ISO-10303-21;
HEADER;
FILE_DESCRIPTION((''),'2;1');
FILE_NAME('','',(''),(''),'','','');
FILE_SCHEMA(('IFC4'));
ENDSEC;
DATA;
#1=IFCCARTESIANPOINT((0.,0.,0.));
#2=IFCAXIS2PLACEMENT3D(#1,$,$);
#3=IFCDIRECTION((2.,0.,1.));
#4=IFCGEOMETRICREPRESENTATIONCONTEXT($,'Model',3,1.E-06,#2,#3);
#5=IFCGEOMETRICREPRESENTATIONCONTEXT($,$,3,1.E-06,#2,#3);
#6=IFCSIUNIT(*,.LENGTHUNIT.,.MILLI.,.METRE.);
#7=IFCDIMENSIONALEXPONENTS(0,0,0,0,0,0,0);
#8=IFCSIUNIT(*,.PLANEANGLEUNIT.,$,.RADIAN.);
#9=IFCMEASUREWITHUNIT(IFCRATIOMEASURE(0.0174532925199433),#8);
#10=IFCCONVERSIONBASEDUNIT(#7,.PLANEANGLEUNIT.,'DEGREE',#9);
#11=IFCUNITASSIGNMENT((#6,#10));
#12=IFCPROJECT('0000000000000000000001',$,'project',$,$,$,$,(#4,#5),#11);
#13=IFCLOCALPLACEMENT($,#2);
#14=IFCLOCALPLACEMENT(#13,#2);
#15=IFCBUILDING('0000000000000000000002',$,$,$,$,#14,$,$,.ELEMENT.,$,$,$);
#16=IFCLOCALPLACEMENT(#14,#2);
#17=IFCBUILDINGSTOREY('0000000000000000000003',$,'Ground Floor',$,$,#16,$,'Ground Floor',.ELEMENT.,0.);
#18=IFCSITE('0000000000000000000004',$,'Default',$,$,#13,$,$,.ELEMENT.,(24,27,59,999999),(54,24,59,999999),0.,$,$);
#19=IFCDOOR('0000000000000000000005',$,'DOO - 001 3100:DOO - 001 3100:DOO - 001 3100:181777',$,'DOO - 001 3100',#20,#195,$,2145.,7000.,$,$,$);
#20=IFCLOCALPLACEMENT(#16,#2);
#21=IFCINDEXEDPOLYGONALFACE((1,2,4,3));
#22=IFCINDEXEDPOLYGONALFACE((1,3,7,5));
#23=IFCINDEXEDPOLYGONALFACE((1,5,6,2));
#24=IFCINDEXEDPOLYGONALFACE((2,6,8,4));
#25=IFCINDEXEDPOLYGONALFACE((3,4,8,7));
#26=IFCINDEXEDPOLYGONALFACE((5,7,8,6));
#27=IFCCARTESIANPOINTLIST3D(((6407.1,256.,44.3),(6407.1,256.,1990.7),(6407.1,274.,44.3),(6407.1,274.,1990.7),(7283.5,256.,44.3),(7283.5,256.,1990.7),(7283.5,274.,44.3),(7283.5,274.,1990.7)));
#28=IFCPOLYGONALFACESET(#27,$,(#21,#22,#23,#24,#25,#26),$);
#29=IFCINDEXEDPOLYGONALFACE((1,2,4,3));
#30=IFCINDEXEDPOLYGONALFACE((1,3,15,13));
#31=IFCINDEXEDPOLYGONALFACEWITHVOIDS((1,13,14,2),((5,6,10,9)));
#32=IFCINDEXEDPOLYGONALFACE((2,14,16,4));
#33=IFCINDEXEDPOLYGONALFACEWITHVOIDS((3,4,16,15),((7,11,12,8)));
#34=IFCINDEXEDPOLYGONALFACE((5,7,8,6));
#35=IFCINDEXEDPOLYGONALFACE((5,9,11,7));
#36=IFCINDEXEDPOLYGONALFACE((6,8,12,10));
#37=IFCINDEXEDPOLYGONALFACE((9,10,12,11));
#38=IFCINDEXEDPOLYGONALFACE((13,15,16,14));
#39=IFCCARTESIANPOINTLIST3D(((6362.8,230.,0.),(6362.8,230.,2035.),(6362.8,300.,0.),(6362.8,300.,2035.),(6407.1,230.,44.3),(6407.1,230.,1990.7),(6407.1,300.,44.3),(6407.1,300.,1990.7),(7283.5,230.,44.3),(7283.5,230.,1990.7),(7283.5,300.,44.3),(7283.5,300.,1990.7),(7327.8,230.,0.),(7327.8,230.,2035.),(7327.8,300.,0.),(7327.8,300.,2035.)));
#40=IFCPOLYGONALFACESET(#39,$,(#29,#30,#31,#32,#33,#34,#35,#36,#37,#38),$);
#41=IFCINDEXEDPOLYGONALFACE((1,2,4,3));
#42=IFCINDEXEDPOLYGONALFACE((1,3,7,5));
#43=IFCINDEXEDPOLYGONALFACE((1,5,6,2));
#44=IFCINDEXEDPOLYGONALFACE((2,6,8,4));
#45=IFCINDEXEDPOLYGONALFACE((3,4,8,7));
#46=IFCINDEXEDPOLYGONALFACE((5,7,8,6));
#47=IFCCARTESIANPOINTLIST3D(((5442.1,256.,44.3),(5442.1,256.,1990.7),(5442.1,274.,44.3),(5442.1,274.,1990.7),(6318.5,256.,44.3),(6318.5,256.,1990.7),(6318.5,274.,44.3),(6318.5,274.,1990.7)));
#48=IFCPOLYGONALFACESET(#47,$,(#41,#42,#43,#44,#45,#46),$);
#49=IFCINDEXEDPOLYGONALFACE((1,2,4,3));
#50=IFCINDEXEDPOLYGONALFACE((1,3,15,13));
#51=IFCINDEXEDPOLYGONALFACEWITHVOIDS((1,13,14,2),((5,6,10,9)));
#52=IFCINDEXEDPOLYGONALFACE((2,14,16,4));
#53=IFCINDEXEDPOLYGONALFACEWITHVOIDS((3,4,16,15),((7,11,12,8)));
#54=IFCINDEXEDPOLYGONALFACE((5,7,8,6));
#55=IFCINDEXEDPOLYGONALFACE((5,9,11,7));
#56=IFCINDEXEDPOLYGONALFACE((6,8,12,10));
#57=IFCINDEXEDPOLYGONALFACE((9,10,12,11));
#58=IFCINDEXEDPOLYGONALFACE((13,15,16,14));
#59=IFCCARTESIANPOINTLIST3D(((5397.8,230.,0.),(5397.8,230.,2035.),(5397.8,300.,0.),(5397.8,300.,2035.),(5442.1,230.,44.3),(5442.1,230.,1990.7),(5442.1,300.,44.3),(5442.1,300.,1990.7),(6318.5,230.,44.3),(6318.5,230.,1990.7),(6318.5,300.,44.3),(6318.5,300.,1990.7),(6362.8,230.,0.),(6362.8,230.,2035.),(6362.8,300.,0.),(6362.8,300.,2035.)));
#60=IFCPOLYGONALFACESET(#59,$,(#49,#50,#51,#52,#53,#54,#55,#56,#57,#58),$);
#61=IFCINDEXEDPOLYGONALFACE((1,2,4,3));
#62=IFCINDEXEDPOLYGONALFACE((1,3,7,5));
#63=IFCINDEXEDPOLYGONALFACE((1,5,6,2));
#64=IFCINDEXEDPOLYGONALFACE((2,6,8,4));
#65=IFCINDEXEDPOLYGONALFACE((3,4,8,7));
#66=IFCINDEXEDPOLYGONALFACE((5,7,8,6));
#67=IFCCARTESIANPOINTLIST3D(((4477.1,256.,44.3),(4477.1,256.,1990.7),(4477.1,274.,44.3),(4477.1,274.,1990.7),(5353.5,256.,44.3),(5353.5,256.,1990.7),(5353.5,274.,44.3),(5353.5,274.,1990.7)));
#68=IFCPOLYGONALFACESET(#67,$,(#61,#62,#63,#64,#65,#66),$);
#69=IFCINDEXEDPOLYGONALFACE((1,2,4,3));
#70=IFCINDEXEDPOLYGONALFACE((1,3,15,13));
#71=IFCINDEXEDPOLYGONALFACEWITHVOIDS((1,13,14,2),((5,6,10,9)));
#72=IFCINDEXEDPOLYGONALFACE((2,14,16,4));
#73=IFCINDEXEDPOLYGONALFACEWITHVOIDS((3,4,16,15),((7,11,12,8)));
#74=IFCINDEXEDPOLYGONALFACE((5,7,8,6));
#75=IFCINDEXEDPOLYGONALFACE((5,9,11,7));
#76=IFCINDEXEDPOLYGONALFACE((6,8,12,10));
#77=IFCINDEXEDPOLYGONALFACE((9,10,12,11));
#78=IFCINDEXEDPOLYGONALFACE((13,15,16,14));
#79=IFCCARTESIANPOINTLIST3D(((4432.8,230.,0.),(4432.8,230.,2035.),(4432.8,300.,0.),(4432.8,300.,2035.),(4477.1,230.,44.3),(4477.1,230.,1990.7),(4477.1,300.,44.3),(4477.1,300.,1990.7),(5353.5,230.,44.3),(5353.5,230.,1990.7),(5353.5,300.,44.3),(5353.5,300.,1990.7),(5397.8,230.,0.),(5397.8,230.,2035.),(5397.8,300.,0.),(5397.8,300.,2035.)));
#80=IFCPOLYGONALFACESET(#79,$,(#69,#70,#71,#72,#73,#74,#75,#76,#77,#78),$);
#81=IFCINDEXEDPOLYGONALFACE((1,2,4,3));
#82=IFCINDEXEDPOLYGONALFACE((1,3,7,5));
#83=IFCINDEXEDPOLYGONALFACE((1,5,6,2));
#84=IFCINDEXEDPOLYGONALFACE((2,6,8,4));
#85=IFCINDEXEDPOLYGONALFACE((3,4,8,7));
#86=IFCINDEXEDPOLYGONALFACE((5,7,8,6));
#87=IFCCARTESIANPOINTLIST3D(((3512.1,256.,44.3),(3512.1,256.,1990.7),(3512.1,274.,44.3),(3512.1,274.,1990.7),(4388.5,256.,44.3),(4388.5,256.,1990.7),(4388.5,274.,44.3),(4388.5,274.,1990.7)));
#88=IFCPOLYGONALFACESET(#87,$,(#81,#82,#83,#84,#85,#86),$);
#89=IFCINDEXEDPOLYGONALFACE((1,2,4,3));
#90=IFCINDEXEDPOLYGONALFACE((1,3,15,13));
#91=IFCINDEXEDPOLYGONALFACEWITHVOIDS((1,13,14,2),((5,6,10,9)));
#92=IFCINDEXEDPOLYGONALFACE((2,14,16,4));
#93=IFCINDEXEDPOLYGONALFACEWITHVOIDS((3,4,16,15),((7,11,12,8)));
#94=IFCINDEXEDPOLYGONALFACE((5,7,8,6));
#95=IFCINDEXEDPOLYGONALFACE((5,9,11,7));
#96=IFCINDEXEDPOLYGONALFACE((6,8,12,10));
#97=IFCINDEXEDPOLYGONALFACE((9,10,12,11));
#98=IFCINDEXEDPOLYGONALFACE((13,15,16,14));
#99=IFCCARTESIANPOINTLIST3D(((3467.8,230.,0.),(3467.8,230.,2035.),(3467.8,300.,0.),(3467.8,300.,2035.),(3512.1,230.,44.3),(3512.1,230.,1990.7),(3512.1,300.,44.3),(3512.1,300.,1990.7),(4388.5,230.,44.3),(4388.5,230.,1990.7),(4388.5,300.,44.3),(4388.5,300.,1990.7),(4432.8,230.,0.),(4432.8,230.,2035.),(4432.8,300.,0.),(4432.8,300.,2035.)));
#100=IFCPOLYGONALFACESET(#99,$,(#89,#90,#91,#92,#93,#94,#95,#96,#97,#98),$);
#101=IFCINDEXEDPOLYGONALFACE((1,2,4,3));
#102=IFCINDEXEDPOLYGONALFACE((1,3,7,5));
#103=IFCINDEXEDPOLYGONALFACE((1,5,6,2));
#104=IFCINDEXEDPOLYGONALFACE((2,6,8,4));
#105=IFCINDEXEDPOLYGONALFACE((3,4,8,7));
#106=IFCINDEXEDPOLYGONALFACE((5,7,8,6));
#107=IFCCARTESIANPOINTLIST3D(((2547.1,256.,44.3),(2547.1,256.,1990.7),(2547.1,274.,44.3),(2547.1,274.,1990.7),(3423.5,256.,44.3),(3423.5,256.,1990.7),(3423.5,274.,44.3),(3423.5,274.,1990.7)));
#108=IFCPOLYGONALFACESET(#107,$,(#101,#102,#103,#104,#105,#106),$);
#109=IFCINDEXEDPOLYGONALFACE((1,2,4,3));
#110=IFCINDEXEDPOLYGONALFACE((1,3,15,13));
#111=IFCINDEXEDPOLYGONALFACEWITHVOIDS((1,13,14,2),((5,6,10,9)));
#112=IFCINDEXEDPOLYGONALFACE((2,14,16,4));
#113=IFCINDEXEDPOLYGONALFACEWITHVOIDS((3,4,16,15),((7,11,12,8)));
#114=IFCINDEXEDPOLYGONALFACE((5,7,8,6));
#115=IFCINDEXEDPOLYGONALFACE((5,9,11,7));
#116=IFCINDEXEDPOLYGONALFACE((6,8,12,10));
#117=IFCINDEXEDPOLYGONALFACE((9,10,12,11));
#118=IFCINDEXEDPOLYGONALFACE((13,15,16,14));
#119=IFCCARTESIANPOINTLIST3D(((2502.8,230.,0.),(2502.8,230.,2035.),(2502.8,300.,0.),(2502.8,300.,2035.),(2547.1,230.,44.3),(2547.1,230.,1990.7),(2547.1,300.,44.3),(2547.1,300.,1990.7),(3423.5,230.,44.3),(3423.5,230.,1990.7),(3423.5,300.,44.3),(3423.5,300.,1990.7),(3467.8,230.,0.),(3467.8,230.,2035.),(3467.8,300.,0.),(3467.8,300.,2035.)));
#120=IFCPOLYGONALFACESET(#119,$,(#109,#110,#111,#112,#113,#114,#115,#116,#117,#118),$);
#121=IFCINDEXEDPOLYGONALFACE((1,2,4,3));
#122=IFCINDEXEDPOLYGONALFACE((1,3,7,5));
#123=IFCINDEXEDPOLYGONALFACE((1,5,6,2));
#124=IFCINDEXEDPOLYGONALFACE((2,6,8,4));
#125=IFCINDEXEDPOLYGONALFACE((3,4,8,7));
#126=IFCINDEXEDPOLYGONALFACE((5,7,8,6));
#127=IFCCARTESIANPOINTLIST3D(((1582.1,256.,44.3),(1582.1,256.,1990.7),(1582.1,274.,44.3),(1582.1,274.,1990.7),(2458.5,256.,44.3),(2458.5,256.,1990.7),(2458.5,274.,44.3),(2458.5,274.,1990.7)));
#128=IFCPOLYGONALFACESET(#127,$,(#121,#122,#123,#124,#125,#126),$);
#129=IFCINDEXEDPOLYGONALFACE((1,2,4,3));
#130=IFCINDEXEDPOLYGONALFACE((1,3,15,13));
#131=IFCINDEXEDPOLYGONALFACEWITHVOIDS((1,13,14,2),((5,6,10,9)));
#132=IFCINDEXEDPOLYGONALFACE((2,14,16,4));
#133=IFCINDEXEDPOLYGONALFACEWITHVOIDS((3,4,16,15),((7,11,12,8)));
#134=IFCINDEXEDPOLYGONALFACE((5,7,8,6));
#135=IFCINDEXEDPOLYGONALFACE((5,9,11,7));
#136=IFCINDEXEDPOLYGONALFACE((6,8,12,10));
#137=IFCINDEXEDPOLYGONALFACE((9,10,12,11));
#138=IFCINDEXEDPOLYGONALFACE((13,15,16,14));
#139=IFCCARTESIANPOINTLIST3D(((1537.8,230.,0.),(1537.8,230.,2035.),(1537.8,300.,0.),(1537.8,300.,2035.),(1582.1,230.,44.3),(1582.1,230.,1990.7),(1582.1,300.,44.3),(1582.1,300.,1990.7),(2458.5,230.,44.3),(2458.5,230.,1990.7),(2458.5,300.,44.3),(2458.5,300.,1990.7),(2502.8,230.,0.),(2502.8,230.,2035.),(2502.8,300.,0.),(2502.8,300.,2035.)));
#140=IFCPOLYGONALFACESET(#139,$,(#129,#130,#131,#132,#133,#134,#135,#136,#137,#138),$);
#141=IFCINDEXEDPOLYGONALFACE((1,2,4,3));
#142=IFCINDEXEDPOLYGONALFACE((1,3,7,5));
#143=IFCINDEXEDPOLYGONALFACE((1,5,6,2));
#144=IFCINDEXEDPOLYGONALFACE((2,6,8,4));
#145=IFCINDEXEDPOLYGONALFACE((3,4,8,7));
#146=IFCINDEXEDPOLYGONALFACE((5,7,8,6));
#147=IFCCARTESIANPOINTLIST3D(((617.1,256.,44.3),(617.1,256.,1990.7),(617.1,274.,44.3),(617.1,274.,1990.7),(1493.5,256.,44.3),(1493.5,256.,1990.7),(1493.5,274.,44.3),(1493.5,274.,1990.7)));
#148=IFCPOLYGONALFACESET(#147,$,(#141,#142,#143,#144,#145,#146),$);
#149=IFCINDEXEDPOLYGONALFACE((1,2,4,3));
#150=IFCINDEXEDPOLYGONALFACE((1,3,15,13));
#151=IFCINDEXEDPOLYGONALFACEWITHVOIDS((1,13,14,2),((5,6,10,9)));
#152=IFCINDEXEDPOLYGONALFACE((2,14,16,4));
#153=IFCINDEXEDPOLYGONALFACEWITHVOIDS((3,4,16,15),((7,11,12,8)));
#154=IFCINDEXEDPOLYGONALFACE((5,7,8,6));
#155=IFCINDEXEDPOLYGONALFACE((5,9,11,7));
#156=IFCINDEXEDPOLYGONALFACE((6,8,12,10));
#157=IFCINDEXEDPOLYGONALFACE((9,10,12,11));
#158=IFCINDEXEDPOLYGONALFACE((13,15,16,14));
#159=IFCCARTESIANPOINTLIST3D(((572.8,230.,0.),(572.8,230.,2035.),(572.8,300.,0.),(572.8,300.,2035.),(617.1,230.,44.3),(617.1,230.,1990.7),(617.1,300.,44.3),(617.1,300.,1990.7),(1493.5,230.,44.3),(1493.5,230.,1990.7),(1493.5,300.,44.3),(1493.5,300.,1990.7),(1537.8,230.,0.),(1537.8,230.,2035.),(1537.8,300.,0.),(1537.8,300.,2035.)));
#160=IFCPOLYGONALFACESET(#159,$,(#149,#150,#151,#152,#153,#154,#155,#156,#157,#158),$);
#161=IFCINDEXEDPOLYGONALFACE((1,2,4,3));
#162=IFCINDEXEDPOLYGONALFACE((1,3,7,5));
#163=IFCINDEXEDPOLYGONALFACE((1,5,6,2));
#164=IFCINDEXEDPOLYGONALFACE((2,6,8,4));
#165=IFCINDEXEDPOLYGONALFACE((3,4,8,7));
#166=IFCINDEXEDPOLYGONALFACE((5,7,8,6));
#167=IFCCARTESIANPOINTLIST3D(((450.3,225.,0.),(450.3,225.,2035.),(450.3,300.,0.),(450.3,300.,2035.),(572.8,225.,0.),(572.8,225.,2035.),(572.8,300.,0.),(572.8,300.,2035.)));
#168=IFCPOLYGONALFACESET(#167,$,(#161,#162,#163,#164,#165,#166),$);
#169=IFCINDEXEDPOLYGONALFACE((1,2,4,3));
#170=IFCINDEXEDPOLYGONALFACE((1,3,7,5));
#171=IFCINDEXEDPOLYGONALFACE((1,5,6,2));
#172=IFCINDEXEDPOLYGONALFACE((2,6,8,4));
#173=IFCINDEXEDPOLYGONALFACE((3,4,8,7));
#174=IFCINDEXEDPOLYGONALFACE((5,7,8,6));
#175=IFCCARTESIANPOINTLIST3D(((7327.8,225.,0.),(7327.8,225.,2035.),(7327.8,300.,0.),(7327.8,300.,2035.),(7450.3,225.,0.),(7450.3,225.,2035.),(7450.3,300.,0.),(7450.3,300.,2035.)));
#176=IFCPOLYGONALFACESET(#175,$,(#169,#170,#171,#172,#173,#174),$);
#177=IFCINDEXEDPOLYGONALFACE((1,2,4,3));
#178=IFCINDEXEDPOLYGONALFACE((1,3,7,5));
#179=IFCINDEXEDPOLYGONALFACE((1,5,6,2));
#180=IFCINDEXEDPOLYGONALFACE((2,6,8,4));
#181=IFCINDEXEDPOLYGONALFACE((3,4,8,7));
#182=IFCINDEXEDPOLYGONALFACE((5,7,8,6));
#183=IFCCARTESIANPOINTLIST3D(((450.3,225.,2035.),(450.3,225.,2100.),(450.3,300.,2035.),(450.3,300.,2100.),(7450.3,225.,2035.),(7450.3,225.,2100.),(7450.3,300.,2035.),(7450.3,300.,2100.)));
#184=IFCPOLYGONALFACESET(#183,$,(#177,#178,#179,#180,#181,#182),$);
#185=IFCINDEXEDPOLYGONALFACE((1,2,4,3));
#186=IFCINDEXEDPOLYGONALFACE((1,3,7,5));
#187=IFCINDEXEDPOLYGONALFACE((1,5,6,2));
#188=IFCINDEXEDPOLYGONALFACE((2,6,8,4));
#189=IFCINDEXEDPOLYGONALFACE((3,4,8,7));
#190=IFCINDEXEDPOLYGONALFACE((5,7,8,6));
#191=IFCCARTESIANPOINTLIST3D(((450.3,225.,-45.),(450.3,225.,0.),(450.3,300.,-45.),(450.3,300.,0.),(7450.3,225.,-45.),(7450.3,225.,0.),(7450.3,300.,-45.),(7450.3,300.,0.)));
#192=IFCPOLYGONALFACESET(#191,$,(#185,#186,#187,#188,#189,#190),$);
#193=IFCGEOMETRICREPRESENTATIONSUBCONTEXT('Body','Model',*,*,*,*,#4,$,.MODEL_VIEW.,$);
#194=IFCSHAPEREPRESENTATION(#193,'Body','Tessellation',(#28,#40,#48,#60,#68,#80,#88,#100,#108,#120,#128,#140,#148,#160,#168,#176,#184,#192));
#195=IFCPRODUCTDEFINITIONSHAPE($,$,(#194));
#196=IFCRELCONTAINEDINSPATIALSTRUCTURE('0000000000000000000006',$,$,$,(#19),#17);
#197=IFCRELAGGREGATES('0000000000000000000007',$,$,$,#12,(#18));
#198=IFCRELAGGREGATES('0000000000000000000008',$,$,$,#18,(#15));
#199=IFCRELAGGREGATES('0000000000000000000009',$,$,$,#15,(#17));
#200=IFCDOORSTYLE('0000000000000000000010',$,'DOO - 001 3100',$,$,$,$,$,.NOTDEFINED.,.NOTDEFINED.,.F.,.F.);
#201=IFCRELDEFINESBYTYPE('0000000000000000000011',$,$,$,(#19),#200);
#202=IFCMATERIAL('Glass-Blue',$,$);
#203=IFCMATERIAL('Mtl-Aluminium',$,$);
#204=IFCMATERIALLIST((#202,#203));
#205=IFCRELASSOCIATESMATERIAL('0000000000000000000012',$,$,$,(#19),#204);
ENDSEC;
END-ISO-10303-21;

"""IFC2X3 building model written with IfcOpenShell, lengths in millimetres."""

from ifc_helpers import new_model, entity, si_unit, converted_unit, direction, frame, frame_2d, origin, origin_2d_with_axis, place, context, subcontext, project, spatial, polyline, rectangle, outline, extrude, source, transform, mapped, material, material_list, type_object, type_shapes, element, save


model = new_model("IFC2X3")

# Units and contexts
model_context = context("Model", 3, precision=1e-06, world=origin(), true_north=direction((2.0, 0.0, 1.0)))
context_of_model = context(None, 3, precision=1e-06, world=origin(), true_north=direction((2.0, 0.0, 1.0)))
body_context = subcontext(model_context, "Body", "Model", "MODEL_VIEW")
ifc_project = project(units=[si_unit("LENGTHUNIT", "METRE", prefix="MILLI"), converted_unit("PLANEANGLEUNIT", "DEGREE", entity("IfcRatioMeasure", 0.0174532925199433), si_unit("PLANEANGLEUNIT", "RADIAN"), dimensions=[0, 0, 0, 0, 0, 0, 0])], contexts=[model_context, context_of_model])

# Site, building, storey
site_placement = place(None, origin())
site = spatial("IfcSite", under=ifc_project, at=site_placement, Name="Default", CompositionType="ELEMENT", RefLatitude=(24, 27, 59, 999999), RefLongitude=(54, 24, 59, 999999), RefElevation=0.0)
building_placement = place(site_placement, origin())
building = spatial("IfcBuilding", under=site, at=building_placement, CompositionType="ELEMENT")
storey_placement = place(building_placement, origin())
storey = spatial("IfcBuildingStorey", under=building, at=storey_placement, Name="Ground Floor", LongName="Ground Floor", CompositionType="ELEMENT", Elevation=0.0)

# Door
ifc_material_1 = material(Name="Glass-Blue")
ifc_material_2 = material(Name="Mtl-Aluminium")
ifc_material_list = material_list([ifc_material_1, ifc_material_2])
door_style = type_object("IfcDoorStyle", Name="DOO - 001 3100", ConstructionType="NOTDEFINED", OperationType="NOTDEFINED", ParameterTakesPrecedence=False, Sizeable=False)
shared_shape = source(origin(), body_context, "Body", "SweptSolid", [
    extrude(rectangle(XDim=876.4, YDim=18.0, at=frame_2d((0.0, 0.0), x_axis=(1.0, 0.0))), frame((6845.3, 265.0, 44.3), z_axis=(0.0, 0.0, 1.0), x_axis=(-1.0, 0.0, 0.0)), (0.0, 0.0, 1.0), 1946.4),
    extrude(outline(polyline([(-482.5, -1017.5), (482.5, -1017.5), (482.5, 1017.5), (-482.5, 1017.5), (-482.5, -1017.5)]), holes=[polyline([(438.2, 973.2), (438.2, -973.2), (-438.2, -973.2), (-438.2, 973.2), (438.2, 973.2)])]), frame((6845.3, 230.0, 1017.5), z_axis=(0.0, 1.0, 0.0), x_axis=(-1.0, 0.0, 0.0)), (0.0, 0.0, 1.0), 70.0),
    extrude(rectangle(XDim=876.4, YDim=18.0, at=frame_2d((0.0, 0.0), x_axis=(1.0, 0.0))), frame((5880.3, 265.0, 44.3), z_axis=(0.0, 0.0, 1.0), x_axis=(-1.0, 0.0, 0.0)), (0.0, 0.0, 1.0), 1946.4),
    extrude(outline(polyline([(-482.5, -1017.5), (482.5, -1017.5), (482.5, 1017.5), (-482.5, 1017.5), (-482.5, -1017.5)]), holes=[polyline([(438.2, 973.2), (438.2, -973.2), (-438.2, -973.2), (-438.2, 973.2), (438.2, 973.2)])]), frame((5880.3, 230.0, 1017.5), z_axis=(0.0, 1.0, 0.0), x_axis=(-1.0, 0.0, 0.0)), (0.0, 0.0, 1.0), 70.0),
    extrude(rectangle(XDim=876.4, YDim=18.0, at=frame_2d((0.0, 0.0), x_axis=(1.0, 0.0))), frame((4915.3, 265.0, 44.3), z_axis=(0.0, 0.0, 1.0), x_axis=(-1.0, 0.0, 0.0)), (0.0, 0.0, 1.0), 1946.4),
    extrude(outline(polyline([(-482.5, -1017.5), (482.5, -1017.5), (482.5, 1017.5), (-482.5, 1017.5), (-482.5, -1017.5)]), holes=[polyline([(438.2, 973.2), (438.2, -973.2), (-438.2, -973.2), (-438.2, 973.2), (438.2, 973.2)])]), frame((4915.3, 230.0, 1017.5), z_axis=(0.0, 1.0, 0.0), x_axis=(-1.0, 0.0, 0.0)), (0.0, 0.0, 1.0), 70.0),
    extrude(rectangle(XDim=876.4, YDim=18.0, at=frame_2d((0.0, 0.0), x_axis=(1.0, 0.0))), frame((3950.3, 265.0, 44.3), z_axis=(0.0, 0.0, 1.0), x_axis=(-1.0, 0.0, 0.0)), (0.0, 0.0, 1.0), 1946.4),
    extrude(outline(polyline([(-482.5, -1017.5), (482.5, -1017.5), (482.5, 1017.5), (-482.5, 1017.5), (-482.5, -1017.5)]), holes=[polyline([(438.2, 973.2), (438.2, -973.2), (-438.2, -973.2), (-438.2, 973.2), (438.2, 973.2)])]), frame((3950.3, 230.0, 1017.5), z_axis=(0.0, 1.0, 0.0), x_axis=(-1.0, 0.0, 0.0)), (0.0, 0.0, 1.0), 70.0),
    extrude(rectangle(XDim=876.4, YDim=18.0, at=frame_2d((0.0, 0.0), x_axis=(1.0, 0.0))), frame((2985.3, 265.0, 44.3), z_axis=(0.0, 0.0, 1.0), x_axis=(-1.0, 0.0, 0.0)), (0.0, 0.0, 1.0), 1946.4),
    extrude(outline(polyline([(-482.5, -1017.5), (482.5, -1017.5), (482.5, 1017.5), (-482.5, 1017.5), (-482.5, -1017.5)]), holes=[polyline([(438.2, 973.2), (438.2, -973.2), (-438.2, -973.2), (-438.2, 973.2), (438.2, 973.2)])]), frame((2985.3, 230.0, 1017.5), z_axis=(0.0, 1.0, 0.0), x_axis=(-1.0, 0.0, 0.0)), (0.0, 0.0, 1.0), 70.0),
    extrude(rectangle(XDim=876.4, YDim=18.0, at=frame_2d((0.0, 0.0), x_axis=(1.0, 0.0))), frame((2020.3, 265.0, 44.3), z_axis=(0.0, 0.0, 1.0), x_axis=(-1.0, 0.0, 0.0)), (0.0, 0.0, 1.0), 1946.4),
    extrude(outline(polyline([(-482.5, -1017.5), (482.5, -1017.5), (482.5, 1017.5), (-482.5, 1017.5), (-482.5, -1017.5)]), holes=[polyline([(438.2, 973.2), (438.2, -973.2), (-438.2, -973.2), (-438.2, 973.2), (438.2, 973.2)])]), frame((2020.3, 230.0, 1017.5), z_axis=(0.0, 1.0, 0.0), x_axis=(-1.0, 0.0, 0.0)), (0.0, 0.0, 1.0), 70.0),
    extrude(rectangle(XDim=876.4, YDim=18.0, at=frame_2d((0.0, 0.0), x_axis=(1.0, 0.0))), frame((1055.3, 265.0, 44.3), z_axis=(0.0, 0.0, 1.0), x_axis=(-1.0, 0.0, 0.0)), (0.0, 0.0, 1.0), 1946.4),
    extrude(outline(polyline([(-482.5, -1017.5), (482.5, -1017.5), (482.5, 1017.5), (-482.5, 1017.5), (-482.5, -1017.5)]), holes=[polyline([(438.2, 973.2), (438.2, -973.2), (-438.2, -973.2), (-438.2, 973.2), (438.2, 973.2)])]), frame((1055.3, 230.0, 1017.5), z_axis=(0.0, 1.0, 0.0), x_axis=(-1.0, 0.0, 0.0)), (0.0, 0.0, 1.0), 70.0),
    extrude(rectangle(XDim=122.5, YDim=75.0, at=origin_2d_with_axis()), frame((511.6, 262.5, 0.0), z_axis=(0.0, 0.0, 1.0), x_axis=(-1.0, 0.0, 0.0)), (0.0, 0.0, 1.0), 2035.0),
    extrude(rectangle(XDim=122.5, YDim=75.0, at=frame_2d((0.0, 0.0), x_axis=(1.0, 0.0))), frame((7389.1, 262.5, 0.0), z_axis=(0.0, 0.0, 1.0), x_axis=(-1.0, 0.0, 0.0)), (0.0, 0.0, 1.0), 2035.0),
    extrude(rectangle(XDim=7000.0, YDim=75.0, at=origin_2d_with_axis()), frame((3950.3, 262.5, 2035.0), z_axis=(0.0, 0.0, 1.0), x_axis=(-1.0, 0.0, 0.0)), (0.0, 0.0, 1.0), 65.0),
    extrude(rectangle(XDim=7000.0, YDim=75.0, at=origin_2d_with_axis()), frame((3950.3, 262.5, -45.0), z_axis=(0.0, 0.0, 1.0), x_axis=(-1.0, 0.0, 0.0)), (0.0, 0.0, 1.0), 45.0),
])
type_shapes(door_style, [shared_shape])
door_placement = place(storey_placement, origin())
element("IfcDoor", 1, at=door_placement, inside=storey, type_object=door_style, material=ifc_material_list, Name="DOO - 001 3100:DOO - 001 3100:DOO - 001 3100:181777", ObjectType="DOO - 001 3100", OverallHeight=2145.0, OverallWidth=7000.0, context=body_context, shape_type="MappedRepresentation", body=[
    mapped(shared_shape, transform((0.0, 0.0, 0.0), scale=1.0)),
])

save(model, "model.ifc")
